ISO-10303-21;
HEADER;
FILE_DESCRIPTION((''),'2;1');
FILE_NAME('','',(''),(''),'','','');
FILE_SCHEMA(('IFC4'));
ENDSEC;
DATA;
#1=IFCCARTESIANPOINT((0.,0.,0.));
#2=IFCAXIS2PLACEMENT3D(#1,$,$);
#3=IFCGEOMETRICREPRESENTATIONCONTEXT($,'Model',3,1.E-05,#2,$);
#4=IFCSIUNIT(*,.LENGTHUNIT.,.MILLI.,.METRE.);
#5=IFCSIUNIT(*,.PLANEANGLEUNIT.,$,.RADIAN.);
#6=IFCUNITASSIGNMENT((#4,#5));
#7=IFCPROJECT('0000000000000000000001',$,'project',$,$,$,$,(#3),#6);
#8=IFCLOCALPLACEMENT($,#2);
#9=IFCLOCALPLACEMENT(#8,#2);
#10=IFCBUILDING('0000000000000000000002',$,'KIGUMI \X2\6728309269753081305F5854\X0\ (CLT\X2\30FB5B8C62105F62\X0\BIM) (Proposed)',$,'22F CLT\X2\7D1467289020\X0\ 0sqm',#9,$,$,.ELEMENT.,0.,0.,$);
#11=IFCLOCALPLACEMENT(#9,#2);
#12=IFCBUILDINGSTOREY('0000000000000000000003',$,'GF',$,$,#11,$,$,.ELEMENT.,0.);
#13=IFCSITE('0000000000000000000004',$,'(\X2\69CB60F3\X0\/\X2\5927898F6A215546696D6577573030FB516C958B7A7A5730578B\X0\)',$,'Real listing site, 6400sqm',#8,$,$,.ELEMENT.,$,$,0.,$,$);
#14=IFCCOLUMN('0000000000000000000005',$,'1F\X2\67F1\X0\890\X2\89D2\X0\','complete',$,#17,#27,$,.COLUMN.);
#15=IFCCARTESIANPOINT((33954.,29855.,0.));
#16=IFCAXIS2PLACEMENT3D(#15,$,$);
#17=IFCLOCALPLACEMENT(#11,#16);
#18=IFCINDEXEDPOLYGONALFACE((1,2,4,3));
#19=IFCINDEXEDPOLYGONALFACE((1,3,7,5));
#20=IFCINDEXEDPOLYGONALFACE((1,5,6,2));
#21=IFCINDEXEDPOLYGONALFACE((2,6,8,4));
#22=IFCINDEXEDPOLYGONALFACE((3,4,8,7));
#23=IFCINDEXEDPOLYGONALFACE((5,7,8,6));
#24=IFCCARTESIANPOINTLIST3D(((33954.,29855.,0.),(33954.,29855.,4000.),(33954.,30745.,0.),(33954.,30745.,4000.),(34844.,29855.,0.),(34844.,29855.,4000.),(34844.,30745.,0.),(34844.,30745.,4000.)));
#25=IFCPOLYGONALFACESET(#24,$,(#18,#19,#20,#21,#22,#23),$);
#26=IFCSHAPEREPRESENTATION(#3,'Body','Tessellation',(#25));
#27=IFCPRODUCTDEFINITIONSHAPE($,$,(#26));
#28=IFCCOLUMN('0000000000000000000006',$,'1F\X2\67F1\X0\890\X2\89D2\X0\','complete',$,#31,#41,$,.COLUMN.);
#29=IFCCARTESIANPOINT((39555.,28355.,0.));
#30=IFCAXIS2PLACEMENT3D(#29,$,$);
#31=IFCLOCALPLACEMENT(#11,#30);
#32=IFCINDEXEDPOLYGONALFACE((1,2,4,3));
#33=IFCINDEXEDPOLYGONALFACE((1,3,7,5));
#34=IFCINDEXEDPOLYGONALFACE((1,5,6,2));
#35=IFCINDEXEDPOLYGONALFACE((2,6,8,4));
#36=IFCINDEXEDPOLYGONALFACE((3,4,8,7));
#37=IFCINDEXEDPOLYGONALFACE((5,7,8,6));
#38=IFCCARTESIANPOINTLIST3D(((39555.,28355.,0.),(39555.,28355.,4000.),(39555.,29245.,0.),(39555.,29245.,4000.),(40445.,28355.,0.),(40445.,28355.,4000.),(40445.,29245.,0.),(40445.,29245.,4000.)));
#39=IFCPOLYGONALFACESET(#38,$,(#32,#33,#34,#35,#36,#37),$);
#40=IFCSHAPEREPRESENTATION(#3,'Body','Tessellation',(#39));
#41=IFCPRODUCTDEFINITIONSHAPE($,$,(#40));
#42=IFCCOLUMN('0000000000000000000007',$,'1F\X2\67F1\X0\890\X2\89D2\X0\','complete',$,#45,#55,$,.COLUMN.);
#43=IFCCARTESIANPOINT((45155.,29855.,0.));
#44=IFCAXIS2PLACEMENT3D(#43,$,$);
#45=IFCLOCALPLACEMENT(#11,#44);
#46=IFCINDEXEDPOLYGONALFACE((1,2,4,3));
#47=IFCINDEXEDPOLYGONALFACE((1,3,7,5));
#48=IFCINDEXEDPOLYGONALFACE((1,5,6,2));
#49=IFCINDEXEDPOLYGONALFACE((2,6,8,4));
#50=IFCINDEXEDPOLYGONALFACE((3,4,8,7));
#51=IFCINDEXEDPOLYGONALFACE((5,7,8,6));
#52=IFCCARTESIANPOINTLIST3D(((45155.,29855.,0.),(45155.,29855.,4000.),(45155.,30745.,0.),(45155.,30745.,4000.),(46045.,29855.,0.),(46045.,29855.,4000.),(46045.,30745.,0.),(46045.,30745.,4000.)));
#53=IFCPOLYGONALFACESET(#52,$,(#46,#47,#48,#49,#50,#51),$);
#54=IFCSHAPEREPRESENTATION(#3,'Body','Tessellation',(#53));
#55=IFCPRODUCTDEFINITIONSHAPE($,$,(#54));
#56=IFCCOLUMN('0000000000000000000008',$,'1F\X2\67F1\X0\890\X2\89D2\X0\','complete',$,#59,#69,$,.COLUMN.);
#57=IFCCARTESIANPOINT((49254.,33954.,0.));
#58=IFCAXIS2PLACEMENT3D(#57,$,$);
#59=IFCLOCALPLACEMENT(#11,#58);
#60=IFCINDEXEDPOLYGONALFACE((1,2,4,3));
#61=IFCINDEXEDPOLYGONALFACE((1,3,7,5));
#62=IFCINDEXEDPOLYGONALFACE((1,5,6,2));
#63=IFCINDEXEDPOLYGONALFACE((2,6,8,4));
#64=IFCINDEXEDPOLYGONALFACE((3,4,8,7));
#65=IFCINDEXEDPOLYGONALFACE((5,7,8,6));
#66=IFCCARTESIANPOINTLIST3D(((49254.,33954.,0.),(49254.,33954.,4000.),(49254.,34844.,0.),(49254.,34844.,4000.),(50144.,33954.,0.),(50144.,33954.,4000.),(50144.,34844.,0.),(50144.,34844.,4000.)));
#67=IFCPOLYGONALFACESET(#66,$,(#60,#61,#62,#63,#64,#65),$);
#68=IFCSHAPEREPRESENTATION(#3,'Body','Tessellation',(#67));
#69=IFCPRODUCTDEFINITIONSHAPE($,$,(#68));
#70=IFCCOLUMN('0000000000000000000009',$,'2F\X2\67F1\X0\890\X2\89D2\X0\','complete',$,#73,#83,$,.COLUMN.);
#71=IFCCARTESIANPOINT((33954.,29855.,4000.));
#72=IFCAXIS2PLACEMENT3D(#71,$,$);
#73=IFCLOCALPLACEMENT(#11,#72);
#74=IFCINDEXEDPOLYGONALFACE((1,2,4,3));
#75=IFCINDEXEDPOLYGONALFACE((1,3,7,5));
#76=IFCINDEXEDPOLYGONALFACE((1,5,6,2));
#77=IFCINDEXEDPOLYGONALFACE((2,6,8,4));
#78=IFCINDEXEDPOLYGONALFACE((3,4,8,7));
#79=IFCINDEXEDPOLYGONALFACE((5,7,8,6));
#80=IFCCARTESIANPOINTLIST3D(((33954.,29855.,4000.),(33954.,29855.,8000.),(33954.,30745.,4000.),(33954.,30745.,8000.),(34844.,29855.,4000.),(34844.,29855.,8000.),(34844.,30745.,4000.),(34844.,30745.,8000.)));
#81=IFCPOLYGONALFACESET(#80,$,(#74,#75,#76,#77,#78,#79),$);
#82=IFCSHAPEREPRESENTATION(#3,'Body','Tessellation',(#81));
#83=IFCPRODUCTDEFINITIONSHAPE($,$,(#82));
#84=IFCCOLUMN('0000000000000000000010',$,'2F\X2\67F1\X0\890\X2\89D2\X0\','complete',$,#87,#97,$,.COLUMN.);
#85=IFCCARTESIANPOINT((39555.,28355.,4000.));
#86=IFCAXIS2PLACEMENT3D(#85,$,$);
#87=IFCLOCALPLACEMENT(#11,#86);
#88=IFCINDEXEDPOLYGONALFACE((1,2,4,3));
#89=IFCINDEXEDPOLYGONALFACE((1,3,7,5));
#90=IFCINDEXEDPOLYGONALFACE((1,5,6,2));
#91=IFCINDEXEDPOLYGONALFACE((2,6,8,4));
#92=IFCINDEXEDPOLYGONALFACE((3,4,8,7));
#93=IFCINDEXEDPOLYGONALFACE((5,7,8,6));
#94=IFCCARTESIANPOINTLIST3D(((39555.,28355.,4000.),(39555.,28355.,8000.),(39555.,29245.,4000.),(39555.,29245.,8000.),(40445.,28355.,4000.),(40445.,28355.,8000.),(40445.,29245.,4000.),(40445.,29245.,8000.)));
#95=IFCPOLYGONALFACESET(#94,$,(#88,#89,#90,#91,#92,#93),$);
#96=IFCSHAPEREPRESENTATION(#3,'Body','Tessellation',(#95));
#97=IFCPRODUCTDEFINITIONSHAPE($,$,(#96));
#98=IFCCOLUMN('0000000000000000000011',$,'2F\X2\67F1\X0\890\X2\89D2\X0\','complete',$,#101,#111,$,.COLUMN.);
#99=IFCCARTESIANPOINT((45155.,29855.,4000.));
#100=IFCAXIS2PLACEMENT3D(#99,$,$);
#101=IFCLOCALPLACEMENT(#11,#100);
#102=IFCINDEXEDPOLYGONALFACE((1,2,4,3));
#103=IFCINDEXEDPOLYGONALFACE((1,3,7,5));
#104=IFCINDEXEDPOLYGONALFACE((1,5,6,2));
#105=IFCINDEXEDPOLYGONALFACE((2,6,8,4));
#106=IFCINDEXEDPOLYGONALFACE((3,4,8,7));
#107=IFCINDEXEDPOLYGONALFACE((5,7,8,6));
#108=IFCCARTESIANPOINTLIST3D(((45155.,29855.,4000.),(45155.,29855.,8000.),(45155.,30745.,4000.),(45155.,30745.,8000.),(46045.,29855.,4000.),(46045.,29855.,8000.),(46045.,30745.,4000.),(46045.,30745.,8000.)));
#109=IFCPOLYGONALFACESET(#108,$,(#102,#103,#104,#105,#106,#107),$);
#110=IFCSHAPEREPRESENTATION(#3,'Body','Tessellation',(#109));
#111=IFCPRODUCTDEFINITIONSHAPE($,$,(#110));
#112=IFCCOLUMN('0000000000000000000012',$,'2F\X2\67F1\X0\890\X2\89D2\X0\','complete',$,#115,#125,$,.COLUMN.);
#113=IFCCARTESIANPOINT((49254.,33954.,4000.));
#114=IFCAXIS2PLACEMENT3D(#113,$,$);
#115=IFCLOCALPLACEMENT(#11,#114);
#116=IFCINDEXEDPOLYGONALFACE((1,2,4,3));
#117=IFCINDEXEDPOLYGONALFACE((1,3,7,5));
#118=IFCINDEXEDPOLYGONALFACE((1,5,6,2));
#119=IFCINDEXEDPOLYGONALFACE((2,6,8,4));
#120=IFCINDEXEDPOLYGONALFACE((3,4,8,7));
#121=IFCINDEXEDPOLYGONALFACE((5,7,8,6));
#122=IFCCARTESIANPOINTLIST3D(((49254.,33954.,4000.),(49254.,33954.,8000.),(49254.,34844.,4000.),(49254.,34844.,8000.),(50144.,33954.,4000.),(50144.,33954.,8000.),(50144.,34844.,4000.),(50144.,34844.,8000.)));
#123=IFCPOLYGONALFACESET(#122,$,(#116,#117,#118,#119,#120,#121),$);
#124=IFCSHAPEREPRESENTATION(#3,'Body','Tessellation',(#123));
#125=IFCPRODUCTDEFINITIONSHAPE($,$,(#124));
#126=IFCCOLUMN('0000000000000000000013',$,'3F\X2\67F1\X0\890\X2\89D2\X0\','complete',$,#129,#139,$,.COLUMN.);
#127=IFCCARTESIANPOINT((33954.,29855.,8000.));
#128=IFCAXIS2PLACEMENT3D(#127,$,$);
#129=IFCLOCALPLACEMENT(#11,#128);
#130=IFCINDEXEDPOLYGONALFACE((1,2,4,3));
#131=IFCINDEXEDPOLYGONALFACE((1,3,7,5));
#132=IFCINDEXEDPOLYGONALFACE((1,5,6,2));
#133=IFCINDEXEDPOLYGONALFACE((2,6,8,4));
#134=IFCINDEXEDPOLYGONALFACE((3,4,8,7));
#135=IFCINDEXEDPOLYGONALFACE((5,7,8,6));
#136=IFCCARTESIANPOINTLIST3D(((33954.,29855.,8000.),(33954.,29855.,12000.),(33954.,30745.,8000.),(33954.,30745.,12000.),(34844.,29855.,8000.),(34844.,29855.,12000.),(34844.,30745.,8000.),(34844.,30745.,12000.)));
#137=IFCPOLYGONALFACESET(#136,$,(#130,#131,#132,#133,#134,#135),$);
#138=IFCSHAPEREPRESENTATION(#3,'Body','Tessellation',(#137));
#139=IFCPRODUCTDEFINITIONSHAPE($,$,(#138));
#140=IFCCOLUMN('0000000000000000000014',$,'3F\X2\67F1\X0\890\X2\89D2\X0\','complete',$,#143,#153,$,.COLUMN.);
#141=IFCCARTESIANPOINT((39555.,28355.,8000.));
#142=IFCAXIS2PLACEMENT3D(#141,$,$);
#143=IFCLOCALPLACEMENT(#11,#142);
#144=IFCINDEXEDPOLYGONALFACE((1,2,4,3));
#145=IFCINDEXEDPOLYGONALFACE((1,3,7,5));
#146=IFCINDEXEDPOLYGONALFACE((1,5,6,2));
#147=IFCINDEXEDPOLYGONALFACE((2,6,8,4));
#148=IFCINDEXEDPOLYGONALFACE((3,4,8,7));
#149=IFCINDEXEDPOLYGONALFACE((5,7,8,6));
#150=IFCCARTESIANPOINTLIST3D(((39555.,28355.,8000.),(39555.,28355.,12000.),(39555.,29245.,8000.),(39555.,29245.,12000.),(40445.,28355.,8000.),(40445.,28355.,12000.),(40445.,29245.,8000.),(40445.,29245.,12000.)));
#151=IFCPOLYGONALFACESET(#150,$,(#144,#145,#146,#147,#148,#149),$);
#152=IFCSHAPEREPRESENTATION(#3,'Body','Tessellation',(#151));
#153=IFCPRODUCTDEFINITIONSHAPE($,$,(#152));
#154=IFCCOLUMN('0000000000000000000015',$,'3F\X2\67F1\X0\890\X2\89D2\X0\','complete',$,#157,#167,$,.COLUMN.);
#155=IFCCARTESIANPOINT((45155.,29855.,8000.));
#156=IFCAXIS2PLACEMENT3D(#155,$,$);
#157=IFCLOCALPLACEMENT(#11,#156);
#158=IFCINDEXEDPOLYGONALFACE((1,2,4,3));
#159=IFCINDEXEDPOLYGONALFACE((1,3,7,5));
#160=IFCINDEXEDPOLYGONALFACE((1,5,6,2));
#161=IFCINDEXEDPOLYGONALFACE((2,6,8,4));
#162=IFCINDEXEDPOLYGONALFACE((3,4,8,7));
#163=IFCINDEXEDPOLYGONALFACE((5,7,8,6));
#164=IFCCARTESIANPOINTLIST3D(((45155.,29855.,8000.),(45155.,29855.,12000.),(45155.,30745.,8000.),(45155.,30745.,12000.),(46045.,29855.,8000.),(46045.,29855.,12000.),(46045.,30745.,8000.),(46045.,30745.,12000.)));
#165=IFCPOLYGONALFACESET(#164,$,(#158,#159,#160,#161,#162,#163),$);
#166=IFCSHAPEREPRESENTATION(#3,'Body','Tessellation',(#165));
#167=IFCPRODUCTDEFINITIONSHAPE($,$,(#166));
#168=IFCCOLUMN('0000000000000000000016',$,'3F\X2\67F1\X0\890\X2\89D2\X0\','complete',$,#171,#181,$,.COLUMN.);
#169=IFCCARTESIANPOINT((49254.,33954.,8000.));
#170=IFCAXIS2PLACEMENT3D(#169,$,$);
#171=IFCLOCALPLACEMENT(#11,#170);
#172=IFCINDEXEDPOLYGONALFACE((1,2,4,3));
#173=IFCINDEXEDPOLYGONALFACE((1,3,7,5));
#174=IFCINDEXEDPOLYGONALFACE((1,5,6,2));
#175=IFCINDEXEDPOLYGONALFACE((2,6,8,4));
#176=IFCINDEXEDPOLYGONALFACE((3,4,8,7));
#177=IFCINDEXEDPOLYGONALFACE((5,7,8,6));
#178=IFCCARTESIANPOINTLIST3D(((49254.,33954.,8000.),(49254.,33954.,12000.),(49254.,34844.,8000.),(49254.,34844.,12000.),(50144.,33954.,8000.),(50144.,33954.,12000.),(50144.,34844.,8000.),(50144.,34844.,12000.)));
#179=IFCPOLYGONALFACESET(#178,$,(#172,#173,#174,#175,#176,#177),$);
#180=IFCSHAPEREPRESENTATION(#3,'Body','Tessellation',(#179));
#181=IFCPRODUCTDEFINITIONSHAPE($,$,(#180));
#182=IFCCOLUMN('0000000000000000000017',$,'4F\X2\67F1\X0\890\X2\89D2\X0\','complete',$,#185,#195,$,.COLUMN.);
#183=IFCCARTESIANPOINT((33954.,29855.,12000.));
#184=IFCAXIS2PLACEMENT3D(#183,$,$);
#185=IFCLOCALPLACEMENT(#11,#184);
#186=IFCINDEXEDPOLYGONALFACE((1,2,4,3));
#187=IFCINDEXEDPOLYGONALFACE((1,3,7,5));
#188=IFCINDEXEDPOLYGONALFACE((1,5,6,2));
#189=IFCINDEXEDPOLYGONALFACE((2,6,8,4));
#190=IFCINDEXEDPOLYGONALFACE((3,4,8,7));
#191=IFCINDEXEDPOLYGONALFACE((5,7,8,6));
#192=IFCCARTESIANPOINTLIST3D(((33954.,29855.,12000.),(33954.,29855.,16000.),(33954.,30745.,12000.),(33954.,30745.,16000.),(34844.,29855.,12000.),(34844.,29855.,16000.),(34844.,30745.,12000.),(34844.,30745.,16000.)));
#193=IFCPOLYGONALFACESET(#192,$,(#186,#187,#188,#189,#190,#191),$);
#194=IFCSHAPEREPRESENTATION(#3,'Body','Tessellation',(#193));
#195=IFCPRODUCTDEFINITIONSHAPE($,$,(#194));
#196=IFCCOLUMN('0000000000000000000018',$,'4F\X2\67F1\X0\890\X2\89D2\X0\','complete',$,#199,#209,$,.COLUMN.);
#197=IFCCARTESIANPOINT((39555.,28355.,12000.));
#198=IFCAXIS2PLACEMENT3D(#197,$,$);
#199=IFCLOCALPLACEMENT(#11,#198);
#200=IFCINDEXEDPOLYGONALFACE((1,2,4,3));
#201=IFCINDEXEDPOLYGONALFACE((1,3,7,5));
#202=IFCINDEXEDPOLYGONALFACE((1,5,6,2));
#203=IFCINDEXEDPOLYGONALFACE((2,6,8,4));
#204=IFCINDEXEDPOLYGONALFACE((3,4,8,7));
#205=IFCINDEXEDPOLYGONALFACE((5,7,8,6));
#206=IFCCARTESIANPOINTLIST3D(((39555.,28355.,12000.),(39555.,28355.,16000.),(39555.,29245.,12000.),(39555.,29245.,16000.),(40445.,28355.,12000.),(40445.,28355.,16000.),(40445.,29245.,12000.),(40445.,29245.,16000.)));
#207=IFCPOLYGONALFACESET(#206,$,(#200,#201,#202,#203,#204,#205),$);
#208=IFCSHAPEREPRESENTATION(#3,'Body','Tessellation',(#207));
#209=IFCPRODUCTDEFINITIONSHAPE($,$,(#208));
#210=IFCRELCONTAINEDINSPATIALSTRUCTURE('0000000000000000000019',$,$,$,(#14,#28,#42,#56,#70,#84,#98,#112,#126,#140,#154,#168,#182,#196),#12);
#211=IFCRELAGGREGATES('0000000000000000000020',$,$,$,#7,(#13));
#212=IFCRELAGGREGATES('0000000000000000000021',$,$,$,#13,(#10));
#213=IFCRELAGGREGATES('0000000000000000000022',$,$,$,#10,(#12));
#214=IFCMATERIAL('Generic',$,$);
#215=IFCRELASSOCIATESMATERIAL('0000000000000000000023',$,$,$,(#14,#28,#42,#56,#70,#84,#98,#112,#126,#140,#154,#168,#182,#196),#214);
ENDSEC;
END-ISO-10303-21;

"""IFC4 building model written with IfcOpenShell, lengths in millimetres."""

from ifc_helpers import new_model, si_unit, frame, frame_2d, origin, place, context, project, spatial, rectangle, extrude, material, element, save


model = new_model("IFC4")

# Units and contexts
model_context = context("Model", 3, precision=1e-05, world=origin())
ifc_project = project(units=[si_unit("LENGTHUNIT", "METRE", prefix="MILLI"), si_unit("PLANEANGLEUNIT", "RADIAN")], contexts=[model_context])

# Site, building, storey
site_placement = place(None, origin())
site = spatial("IfcSite", under=ifc_project, at=site_placement, Name="(構想/大規模商業敷地・公開空地型)", ObjectType="Real listing site, 6400sqm", CompositionType="ELEMENT", RefElevation=0.0)
building_placement = place(site_placement, origin())
building = spatial("IfcBuilding", under=site, at=building_placement, Name="KIGUMI 木を極めた塔 (CLT・完成形BIM) (Proposed)", ObjectType="22F CLT純木造 0sqm", CompositionType="ELEMENT", ElevationOfRefHeight=0.0, ElevationOfTerrain=0.0)
storey_placement = place(building_placement, origin())
storey = spatial("IfcBuildingStorey", under=building, at=storey_placement, Name="GF", CompositionType="ELEMENT", Elevation=0.0)

# Columns
ifc_material = material(Name="Generic")
column_1_placement = place(storey_placement, frame((33954.0, 29855.0, 0.0)))
element("IfcColumn", 1, at=column_1_placement, inside=storey, material=ifc_material, Name="1F柱890角", Description="complete", PredefinedType="COLUMN", context=model_context, shape_type="SweptSolid", body=[
    extrude(rectangle(XDim=890.0, YDim=890.0, at=frame_2d((445.0, 445.0))), frame((33954.0, 29855.0, 0.0)), (0.0, 0.0, 1.0), 4000.0),
])
column_2_placement = place(storey_placement, frame((39555.0, 28355.0, 0.0)))
element("IfcColumn", 2, at=column_2_placement, inside=storey, material=ifc_material, Name="1F柱890角", Description="complete", PredefinedType="COLUMN", context=model_context, shape_type="SweptSolid", body=[
    extrude(rectangle(XDim=890.0, YDim=890.0, at=frame_2d((445.0, 445.0))), frame((39555.0, 28355.0, 0.0)), (0.0, 0.0, 1.0), 4000.0),
])
column_3_placement = place(storey_placement, frame((45155.0, 29855.0, 0.0)))
element("IfcColumn", 3, at=column_3_placement, inside=storey, material=ifc_material, Name="1F柱890角", Description="complete", PredefinedType="COLUMN", context=model_context, shape_type="SweptSolid", body=[
    extrude(rectangle(XDim=890.0, YDim=890.0, at=frame_2d((445.0, 445.0))), frame((45155.0, 29855.0, 0.0)), (0.0, 0.0, 1.0), 4000.0),
])
column_4_placement = place(storey_placement, frame((49254.0, 33954.0, 0.0)))
element("IfcColumn", 4, at=column_4_placement, inside=storey, material=ifc_material, Name="1F柱890角", Description="complete", PredefinedType="COLUMN", context=model_context, shape_type="SweptSolid", body=[
    extrude(rectangle(XDim=890.0, YDim=890.0, at=frame_2d((445.0, 445.0))), frame((49254.0, 33954.0, 0.0)), (0.0, 0.0, 1.0), 4000.0),
])
column_5_placement = place(storey_placement, frame((33954.0, 29855.0, 4000.0)))
element("IfcColumn", 5, at=column_5_placement, inside=storey, material=ifc_material, Name="2F柱890角", Description="complete", PredefinedType="COLUMN", context=model_context, shape_type="SweptSolid", body=[
    extrude(rectangle(XDim=890.0, YDim=890.0, at=frame_2d((445.0, 445.0))), frame((33954.0, 29855.0, 4000.0)), (0.0, 0.0, 1.0), 4000.0),
])
column_6_placement = place(storey_placement, frame((39555.0, 28355.0, 4000.0)))
element("IfcColumn", 6, at=column_6_placement, inside=storey, material=ifc_material, Name="2F柱890角", Description="complete", PredefinedType="COLUMN", context=model_context, shape_type="SweptSolid", body=[
    extrude(rectangle(XDim=890.0, YDim=890.0, at=frame_2d((445.0, 445.0))), frame((39555.0, 28355.0, 4000.0)), (0.0, 0.0, 1.0), 4000.0),
])
column_7_placement = place(storey_placement, frame((45155.0, 29855.0, 4000.0)))
element("IfcColumn", 7, at=column_7_placement, inside=storey, material=ifc_material, Name="2F柱890角", Description="complete", PredefinedType="COLUMN", context=model_context, shape_type="SweptSolid", body=[
    extrude(rectangle(XDim=890.0, YDim=890.0, at=frame_2d((445.0, 445.0))), frame((45155.0, 29855.0, 4000.0)), (0.0, 0.0, 1.0), 4000.0),
])
column_8_placement = place(storey_placement, frame((49254.0, 33954.0, 4000.0)))
element("IfcColumn", 8, at=column_8_placement, inside=storey, material=ifc_material, Name="2F柱890角", Description="complete", PredefinedType="COLUMN", context=model_context, shape_type="SweptSolid", body=[
    extrude(rectangle(XDim=890.0, YDim=890.0, at=frame_2d((445.0, 445.0))), frame((49254.0, 33954.0, 4000.0)), (0.0, 0.0, 1.0), 4000.0),
])
column_9_placement = place(storey_placement, frame((33954.0, 29855.0, 8000.0)))
element("IfcColumn", 9, at=column_9_placement, inside=storey, material=ifc_material, Name="3F柱890角", Description="complete", PredefinedType="COLUMN", context=model_context, shape_type="SweptSolid", body=[
    extrude(rectangle(XDim=890.0, YDim=890.0, at=frame_2d((445.0, 445.0))), frame((33954.0, 29855.0, 8000.0)), (0.0, 0.0, 1.0), 4000.0),
])
column_10_placement = place(storey_placement, frame((39555.0, 28355.0, 8000.0)))
element("IfcColumn", 10, at=column_10_placement, inside=storey, material=ifc_material, Name="3F柱890角", Description="complete", PredefinedType="COLUMN", context=model_context, shape_type="SweptSolid", body=[
    extrude(rectangle(XDim=890.0, YDim=890.0, at=frame_2d((445.0, 445.0))), frame((39555.0, 28355.0, 8000.0)), (0.0, 0.0, 1.0), 4000.0),
])
column_11_placement = place(storey_placement, frame((45155.0, 29855.0, 8000.0)))
element("IfcColumn", 11, at=column_11_placement, inside=storey, material=ifc_material, Name="3F柱890角", Description="complete", PredefinedType="COLUMN", context=model_context, shape_type="SweptSolid", body=[
    extrude(rectangle(XDim=890.0, YDim=890.0, at=frame_2d((445.0, 445.0))), frame((45155.0, 29855.0, 8000.0)), (0.0, 0.0, 1.0), 4000.0),
])
column_12_placement = place(storey_placement, frame((49254.0, 33954.0, 8000.0)))
element("IfcColumn", 12, at=column_12_placement, inside=storey, material=ifc_material, Name="3F柱890角", Description="complete", PredefinedType="COLUMN", context=model_context, shape_type="SweptSolid", body=[
    extrude(rectangle(XDim=890.0, YDim=890.0, at=frame_2d((445.0, 445.0))), frame((49254.0, 33954.0, 8000.0)), (0.0, 0.0, 1.0), 4000.0),
])
column_13_placement = place(storey_placement, frame((33954.0, 29855.0, 12000.0)))
element("IfcColumn", 13, at=column_13_placement, inside=storey, material=ifc_material, Name="4F柱890角", Description="complete", PredefinedType="COLUMN", context=model_context, shape_type="SweptSolid", body=[
    extrude(rectangle(XDim=890.0, YDim=890.0, at=frame_2d((445.0, 445.0))), frame((33954.0, 29855.0, 12000.0)), (0.0, 0.0, 1.0), 4000.0),
])
column_14_placement = place(storey_placement, frame((39555.0, 28355.0, 12000.0)))
element("IfcColumn", 14, at=column_14_placement, inside=storey, material=ifc_material, Name="4F柱890角", Description="complete", PredefinedType="COLUMN", context=model_context, shape_type="SweptSolid", body=[
    extrude(rectangle(XDim=890.0, YDim=890.0, at=frame_2d((445.0, 445.0))), frame((39555.0, 28355.0, 12000.0)), (0.0, 0.0, 1.0), 4000.0),
])

save(model, "model.ifc")
